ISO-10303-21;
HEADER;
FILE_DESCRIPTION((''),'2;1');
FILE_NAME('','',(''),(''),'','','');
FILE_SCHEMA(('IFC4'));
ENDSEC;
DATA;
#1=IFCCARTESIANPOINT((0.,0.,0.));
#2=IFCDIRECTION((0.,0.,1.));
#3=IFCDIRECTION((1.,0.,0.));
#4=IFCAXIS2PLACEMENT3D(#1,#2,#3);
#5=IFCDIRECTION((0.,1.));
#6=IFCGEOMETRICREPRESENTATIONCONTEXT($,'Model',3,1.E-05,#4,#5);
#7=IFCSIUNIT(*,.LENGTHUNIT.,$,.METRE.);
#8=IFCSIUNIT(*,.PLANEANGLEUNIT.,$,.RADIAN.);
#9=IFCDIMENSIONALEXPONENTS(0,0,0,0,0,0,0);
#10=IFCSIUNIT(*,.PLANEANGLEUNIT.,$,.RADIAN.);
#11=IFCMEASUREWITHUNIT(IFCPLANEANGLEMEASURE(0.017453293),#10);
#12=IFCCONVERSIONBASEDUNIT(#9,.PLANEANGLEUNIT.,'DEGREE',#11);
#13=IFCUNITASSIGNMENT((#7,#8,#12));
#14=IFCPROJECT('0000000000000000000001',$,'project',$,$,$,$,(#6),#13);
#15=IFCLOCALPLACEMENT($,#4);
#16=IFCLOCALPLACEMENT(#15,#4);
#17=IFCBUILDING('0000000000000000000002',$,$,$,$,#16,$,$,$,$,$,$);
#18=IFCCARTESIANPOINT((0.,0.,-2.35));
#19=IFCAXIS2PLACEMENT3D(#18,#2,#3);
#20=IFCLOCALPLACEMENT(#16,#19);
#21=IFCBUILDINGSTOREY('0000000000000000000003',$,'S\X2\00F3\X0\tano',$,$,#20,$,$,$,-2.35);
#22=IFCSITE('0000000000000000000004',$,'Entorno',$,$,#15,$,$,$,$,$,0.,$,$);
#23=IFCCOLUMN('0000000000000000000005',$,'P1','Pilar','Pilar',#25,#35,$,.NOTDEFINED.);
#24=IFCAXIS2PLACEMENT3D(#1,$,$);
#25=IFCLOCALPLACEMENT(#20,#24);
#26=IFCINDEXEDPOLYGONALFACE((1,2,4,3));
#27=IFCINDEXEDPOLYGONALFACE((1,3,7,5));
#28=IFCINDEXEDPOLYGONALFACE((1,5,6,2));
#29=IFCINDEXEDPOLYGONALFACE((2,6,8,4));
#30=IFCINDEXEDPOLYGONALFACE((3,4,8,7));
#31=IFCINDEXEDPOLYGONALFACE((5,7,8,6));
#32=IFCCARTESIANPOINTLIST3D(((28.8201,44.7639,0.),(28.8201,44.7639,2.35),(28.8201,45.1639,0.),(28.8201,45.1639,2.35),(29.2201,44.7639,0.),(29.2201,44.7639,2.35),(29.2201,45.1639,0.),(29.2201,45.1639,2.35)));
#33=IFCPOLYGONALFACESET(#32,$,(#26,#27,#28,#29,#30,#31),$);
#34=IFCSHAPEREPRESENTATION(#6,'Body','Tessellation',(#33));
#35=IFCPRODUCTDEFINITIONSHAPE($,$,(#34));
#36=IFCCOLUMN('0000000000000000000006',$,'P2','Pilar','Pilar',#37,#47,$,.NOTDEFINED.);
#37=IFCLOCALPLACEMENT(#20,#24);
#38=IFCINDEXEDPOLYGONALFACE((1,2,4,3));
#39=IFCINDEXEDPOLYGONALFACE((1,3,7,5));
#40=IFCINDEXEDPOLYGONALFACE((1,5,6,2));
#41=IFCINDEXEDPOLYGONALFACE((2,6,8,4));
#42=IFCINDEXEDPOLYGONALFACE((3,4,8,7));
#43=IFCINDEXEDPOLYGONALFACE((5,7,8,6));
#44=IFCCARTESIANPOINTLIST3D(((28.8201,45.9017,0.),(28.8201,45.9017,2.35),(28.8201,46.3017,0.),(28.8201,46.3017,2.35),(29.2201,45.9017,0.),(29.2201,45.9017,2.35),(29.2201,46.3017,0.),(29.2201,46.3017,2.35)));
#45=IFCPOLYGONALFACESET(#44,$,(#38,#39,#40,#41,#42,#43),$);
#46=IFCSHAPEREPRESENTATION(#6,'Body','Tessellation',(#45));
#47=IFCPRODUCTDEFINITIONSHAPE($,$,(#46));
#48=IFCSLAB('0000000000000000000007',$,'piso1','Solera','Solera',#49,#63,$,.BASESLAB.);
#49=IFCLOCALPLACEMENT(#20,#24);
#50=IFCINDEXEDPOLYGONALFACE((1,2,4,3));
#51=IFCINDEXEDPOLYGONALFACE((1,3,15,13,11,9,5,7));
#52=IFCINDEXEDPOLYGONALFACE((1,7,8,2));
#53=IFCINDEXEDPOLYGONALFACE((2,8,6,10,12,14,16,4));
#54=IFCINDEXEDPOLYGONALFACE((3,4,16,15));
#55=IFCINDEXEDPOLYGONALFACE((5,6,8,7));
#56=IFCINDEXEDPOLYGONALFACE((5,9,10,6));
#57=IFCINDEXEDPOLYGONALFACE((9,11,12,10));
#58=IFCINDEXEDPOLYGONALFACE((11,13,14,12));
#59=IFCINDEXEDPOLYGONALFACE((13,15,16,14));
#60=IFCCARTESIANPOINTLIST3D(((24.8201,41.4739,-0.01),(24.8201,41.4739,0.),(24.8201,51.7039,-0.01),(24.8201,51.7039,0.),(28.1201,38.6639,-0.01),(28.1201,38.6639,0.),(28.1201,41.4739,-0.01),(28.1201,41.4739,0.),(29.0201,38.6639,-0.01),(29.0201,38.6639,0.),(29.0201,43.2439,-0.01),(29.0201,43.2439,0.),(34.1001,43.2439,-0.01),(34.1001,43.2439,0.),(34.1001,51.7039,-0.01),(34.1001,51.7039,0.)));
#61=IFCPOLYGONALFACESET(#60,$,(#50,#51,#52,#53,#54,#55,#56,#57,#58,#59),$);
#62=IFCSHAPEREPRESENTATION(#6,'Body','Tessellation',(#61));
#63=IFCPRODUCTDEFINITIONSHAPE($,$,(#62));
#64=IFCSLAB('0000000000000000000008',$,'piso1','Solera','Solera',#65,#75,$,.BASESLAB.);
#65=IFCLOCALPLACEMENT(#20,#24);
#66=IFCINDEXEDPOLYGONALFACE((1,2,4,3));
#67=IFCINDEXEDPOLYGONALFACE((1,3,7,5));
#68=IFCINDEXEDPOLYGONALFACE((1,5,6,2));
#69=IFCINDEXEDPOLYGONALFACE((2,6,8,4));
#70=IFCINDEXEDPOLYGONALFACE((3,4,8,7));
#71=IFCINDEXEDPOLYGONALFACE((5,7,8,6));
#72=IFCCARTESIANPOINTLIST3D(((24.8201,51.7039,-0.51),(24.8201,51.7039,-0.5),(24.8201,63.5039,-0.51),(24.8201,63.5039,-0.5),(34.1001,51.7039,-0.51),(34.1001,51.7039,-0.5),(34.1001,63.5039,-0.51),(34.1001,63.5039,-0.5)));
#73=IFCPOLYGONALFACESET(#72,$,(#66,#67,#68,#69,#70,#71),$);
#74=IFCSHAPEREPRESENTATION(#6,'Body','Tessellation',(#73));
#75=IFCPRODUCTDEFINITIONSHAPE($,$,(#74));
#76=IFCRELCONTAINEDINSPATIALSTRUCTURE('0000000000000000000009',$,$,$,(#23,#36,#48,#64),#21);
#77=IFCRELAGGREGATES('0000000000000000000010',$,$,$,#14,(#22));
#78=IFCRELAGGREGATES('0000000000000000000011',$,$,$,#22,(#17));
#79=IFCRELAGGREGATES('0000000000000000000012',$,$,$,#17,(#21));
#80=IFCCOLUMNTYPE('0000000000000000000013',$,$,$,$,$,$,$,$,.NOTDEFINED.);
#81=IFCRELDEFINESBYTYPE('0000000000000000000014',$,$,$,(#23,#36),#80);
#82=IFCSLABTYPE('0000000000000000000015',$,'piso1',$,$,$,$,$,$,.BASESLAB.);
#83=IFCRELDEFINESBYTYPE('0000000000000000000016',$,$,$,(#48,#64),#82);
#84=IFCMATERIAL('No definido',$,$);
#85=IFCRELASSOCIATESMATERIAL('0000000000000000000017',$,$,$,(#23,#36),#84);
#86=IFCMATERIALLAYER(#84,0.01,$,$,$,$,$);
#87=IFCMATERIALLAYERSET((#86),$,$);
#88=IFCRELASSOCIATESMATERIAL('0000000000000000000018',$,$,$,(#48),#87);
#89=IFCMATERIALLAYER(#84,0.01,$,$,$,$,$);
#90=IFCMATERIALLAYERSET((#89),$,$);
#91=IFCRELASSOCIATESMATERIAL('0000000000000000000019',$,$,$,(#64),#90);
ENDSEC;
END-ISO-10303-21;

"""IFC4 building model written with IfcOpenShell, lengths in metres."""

from ifc_helpers import new_model, entity, si_unit, converted_unit, direction, frame, origin_with_axes, origin_2d_with_axis, place, context, project, spatial, polyline, rectangle, outline, extrude, material, layer, layer_set, layer_usage, type_object, element, save


model = new_model("IFC4")

# Units and contexts
model_context = context("Model", 3, precision=1e-05, world=origin_with_axes(), true_north=direction((0.0, 1.0)))
ifc_project = project(units=[si_unit("LENGTHUNIT", "METRE"), si_unit("PLANEANGLEUNIT", "RADIAN"), converted_unit("PLANEANGLEUNIT", "DEGREE", entity("IfcPlaneAngleMeasure", 0.017453293), si_unit("PLANEANGLEUNIT", "RADIAN"), dimensions=[0, 0, 0, 0, 0, 0, 0])], contexts=[model_context])

# Site, building, storey
site_placement = place(None, origin_with_axes())
site = spatial("IfcSite", under=ifc_project, at=site_placement, Name="Entorno", RefElevation=0.0)
building_placement = place(site_placement, origin_with_axes())
building = spatial("IfcBuilding", under=site, at=building_placement)
storey_placement = place(building_placement, frame((0.0, 0.0, -2.35), z_axis=(0.0, 0.0, 1.0), x_axis=(1.0, 0.0, 0.0)))
storey = spatial("IfcBuildingStorey", under=building, at=storey_placement, Name="Sótano", Elevation=-2.35)

# Columns
ifc_material = material(Name="No definido")
column_type = type_object("IfcColumnType", PredefinedType="NOTDEFINED")
for number, where, z_axis, x_axis, name in (
    (1, (29.0201, 44.9639, 0.0), (0.0, 0.0, 1.0), (1.0, 0.0, 0.0), "P1"),
    (2, (29.0201, 46.1017, 0.0), (0.0, 0.0, 1.0), (1.0, 0.0, 0.0), "P2"),
):
    element("IfcColumn", number, at=place(storey_placement, frame(where, z_axis=z_axis, x_axis=x_axis)), inside=storey, type_object=column_type, material=ifc_material, Name=name, Description="Pilar", ObjectType="Pilar", PredefinedType="NOTDEFINED", context=model_context, shape_type="SweptSolid", body=[
        extrude(rectangle(XDim=0.4, YDim=0.4, at=origin_2d_with_axis()), origin_with_axes(), (0.0, 0.0, 1.0), 2.35),
    ])

# Slabs
ifc_layer_1 = layer(ifc_material, 0.01)
ifc_layer_set_1 = layer_set([ifc_layer_1])
ifc_layer_usage_1 = layer_usage(ifc_layer_set_1, "AXIS3", "POSITIVE", 0.0)
slab_type = type_object("IfcSlabType", Name="piso1", PredefinedType="BASESLAB")
slab_1_placement = place(storey_placement, frame((0.0, 0.0, -0.01), z_axis=(0.0, 0.0, 1.0), x_axis=(1.0, 0.0, 0.0)))
element("IfcSlab", 3, at=slab_1_placement, inside=storey, type_object=slab_type, material=ifc_layer_usage_1, Name="piso1", Description="Solera", ObjectType="Solera", PredefinedType="BASESLAB", context=model_context, shape_type="SweptSolid", body=[
    extrude(outline(polyline([(24.8201, 51.7039), (24.8201, 41.4739), (28.1201, 41.4739), (28.1201, 38.6639), (29.0201, 38.6639), (29.0201, 43.2439), (34.1001, 43.2439), (34.1001, 51.7039), (24.8201, 51.7039)])), origin_with_axes(), (0.0, 0.0, 1.0), 0.01),
])
ifc_layer_2 = layer(ifc_material, 0.01)
ifc_layer_set_2 = layer_set([ifc_layer_2])
ifc_layer_usage_2 = layer_usage(ifc_layer_set_2, "AXIS3", "POSITIVE", 0.0)
slab_2_placement = place(storey_placement, frame((0.0, 0.0, -0.51), z_axis=(0.0, 0.0, 1.0), x_axis=(1.0, 0.0, 0.0)))
element("IfcSlab", 4, at=slab_2_placement, inside=storey, type_object=slab_type, material=ifc_layer_usage_2, Name="piso1", Description="Solera", ObjectType="Solera", PredefinedType="BASESLAB", context=model_context, shape_type="SweptSolid", body=[
    extrude(outline(polyline([(24.8201, 51.7039), (34.1001, 51.7039), (34.1001, 63.5039), (24.8201, 63.5039), (24.8201, 51.7039)])), origin_with_axes(), (0.0, 0.0, 1.0), 0.01),
])

save(model, "model.ifc")
